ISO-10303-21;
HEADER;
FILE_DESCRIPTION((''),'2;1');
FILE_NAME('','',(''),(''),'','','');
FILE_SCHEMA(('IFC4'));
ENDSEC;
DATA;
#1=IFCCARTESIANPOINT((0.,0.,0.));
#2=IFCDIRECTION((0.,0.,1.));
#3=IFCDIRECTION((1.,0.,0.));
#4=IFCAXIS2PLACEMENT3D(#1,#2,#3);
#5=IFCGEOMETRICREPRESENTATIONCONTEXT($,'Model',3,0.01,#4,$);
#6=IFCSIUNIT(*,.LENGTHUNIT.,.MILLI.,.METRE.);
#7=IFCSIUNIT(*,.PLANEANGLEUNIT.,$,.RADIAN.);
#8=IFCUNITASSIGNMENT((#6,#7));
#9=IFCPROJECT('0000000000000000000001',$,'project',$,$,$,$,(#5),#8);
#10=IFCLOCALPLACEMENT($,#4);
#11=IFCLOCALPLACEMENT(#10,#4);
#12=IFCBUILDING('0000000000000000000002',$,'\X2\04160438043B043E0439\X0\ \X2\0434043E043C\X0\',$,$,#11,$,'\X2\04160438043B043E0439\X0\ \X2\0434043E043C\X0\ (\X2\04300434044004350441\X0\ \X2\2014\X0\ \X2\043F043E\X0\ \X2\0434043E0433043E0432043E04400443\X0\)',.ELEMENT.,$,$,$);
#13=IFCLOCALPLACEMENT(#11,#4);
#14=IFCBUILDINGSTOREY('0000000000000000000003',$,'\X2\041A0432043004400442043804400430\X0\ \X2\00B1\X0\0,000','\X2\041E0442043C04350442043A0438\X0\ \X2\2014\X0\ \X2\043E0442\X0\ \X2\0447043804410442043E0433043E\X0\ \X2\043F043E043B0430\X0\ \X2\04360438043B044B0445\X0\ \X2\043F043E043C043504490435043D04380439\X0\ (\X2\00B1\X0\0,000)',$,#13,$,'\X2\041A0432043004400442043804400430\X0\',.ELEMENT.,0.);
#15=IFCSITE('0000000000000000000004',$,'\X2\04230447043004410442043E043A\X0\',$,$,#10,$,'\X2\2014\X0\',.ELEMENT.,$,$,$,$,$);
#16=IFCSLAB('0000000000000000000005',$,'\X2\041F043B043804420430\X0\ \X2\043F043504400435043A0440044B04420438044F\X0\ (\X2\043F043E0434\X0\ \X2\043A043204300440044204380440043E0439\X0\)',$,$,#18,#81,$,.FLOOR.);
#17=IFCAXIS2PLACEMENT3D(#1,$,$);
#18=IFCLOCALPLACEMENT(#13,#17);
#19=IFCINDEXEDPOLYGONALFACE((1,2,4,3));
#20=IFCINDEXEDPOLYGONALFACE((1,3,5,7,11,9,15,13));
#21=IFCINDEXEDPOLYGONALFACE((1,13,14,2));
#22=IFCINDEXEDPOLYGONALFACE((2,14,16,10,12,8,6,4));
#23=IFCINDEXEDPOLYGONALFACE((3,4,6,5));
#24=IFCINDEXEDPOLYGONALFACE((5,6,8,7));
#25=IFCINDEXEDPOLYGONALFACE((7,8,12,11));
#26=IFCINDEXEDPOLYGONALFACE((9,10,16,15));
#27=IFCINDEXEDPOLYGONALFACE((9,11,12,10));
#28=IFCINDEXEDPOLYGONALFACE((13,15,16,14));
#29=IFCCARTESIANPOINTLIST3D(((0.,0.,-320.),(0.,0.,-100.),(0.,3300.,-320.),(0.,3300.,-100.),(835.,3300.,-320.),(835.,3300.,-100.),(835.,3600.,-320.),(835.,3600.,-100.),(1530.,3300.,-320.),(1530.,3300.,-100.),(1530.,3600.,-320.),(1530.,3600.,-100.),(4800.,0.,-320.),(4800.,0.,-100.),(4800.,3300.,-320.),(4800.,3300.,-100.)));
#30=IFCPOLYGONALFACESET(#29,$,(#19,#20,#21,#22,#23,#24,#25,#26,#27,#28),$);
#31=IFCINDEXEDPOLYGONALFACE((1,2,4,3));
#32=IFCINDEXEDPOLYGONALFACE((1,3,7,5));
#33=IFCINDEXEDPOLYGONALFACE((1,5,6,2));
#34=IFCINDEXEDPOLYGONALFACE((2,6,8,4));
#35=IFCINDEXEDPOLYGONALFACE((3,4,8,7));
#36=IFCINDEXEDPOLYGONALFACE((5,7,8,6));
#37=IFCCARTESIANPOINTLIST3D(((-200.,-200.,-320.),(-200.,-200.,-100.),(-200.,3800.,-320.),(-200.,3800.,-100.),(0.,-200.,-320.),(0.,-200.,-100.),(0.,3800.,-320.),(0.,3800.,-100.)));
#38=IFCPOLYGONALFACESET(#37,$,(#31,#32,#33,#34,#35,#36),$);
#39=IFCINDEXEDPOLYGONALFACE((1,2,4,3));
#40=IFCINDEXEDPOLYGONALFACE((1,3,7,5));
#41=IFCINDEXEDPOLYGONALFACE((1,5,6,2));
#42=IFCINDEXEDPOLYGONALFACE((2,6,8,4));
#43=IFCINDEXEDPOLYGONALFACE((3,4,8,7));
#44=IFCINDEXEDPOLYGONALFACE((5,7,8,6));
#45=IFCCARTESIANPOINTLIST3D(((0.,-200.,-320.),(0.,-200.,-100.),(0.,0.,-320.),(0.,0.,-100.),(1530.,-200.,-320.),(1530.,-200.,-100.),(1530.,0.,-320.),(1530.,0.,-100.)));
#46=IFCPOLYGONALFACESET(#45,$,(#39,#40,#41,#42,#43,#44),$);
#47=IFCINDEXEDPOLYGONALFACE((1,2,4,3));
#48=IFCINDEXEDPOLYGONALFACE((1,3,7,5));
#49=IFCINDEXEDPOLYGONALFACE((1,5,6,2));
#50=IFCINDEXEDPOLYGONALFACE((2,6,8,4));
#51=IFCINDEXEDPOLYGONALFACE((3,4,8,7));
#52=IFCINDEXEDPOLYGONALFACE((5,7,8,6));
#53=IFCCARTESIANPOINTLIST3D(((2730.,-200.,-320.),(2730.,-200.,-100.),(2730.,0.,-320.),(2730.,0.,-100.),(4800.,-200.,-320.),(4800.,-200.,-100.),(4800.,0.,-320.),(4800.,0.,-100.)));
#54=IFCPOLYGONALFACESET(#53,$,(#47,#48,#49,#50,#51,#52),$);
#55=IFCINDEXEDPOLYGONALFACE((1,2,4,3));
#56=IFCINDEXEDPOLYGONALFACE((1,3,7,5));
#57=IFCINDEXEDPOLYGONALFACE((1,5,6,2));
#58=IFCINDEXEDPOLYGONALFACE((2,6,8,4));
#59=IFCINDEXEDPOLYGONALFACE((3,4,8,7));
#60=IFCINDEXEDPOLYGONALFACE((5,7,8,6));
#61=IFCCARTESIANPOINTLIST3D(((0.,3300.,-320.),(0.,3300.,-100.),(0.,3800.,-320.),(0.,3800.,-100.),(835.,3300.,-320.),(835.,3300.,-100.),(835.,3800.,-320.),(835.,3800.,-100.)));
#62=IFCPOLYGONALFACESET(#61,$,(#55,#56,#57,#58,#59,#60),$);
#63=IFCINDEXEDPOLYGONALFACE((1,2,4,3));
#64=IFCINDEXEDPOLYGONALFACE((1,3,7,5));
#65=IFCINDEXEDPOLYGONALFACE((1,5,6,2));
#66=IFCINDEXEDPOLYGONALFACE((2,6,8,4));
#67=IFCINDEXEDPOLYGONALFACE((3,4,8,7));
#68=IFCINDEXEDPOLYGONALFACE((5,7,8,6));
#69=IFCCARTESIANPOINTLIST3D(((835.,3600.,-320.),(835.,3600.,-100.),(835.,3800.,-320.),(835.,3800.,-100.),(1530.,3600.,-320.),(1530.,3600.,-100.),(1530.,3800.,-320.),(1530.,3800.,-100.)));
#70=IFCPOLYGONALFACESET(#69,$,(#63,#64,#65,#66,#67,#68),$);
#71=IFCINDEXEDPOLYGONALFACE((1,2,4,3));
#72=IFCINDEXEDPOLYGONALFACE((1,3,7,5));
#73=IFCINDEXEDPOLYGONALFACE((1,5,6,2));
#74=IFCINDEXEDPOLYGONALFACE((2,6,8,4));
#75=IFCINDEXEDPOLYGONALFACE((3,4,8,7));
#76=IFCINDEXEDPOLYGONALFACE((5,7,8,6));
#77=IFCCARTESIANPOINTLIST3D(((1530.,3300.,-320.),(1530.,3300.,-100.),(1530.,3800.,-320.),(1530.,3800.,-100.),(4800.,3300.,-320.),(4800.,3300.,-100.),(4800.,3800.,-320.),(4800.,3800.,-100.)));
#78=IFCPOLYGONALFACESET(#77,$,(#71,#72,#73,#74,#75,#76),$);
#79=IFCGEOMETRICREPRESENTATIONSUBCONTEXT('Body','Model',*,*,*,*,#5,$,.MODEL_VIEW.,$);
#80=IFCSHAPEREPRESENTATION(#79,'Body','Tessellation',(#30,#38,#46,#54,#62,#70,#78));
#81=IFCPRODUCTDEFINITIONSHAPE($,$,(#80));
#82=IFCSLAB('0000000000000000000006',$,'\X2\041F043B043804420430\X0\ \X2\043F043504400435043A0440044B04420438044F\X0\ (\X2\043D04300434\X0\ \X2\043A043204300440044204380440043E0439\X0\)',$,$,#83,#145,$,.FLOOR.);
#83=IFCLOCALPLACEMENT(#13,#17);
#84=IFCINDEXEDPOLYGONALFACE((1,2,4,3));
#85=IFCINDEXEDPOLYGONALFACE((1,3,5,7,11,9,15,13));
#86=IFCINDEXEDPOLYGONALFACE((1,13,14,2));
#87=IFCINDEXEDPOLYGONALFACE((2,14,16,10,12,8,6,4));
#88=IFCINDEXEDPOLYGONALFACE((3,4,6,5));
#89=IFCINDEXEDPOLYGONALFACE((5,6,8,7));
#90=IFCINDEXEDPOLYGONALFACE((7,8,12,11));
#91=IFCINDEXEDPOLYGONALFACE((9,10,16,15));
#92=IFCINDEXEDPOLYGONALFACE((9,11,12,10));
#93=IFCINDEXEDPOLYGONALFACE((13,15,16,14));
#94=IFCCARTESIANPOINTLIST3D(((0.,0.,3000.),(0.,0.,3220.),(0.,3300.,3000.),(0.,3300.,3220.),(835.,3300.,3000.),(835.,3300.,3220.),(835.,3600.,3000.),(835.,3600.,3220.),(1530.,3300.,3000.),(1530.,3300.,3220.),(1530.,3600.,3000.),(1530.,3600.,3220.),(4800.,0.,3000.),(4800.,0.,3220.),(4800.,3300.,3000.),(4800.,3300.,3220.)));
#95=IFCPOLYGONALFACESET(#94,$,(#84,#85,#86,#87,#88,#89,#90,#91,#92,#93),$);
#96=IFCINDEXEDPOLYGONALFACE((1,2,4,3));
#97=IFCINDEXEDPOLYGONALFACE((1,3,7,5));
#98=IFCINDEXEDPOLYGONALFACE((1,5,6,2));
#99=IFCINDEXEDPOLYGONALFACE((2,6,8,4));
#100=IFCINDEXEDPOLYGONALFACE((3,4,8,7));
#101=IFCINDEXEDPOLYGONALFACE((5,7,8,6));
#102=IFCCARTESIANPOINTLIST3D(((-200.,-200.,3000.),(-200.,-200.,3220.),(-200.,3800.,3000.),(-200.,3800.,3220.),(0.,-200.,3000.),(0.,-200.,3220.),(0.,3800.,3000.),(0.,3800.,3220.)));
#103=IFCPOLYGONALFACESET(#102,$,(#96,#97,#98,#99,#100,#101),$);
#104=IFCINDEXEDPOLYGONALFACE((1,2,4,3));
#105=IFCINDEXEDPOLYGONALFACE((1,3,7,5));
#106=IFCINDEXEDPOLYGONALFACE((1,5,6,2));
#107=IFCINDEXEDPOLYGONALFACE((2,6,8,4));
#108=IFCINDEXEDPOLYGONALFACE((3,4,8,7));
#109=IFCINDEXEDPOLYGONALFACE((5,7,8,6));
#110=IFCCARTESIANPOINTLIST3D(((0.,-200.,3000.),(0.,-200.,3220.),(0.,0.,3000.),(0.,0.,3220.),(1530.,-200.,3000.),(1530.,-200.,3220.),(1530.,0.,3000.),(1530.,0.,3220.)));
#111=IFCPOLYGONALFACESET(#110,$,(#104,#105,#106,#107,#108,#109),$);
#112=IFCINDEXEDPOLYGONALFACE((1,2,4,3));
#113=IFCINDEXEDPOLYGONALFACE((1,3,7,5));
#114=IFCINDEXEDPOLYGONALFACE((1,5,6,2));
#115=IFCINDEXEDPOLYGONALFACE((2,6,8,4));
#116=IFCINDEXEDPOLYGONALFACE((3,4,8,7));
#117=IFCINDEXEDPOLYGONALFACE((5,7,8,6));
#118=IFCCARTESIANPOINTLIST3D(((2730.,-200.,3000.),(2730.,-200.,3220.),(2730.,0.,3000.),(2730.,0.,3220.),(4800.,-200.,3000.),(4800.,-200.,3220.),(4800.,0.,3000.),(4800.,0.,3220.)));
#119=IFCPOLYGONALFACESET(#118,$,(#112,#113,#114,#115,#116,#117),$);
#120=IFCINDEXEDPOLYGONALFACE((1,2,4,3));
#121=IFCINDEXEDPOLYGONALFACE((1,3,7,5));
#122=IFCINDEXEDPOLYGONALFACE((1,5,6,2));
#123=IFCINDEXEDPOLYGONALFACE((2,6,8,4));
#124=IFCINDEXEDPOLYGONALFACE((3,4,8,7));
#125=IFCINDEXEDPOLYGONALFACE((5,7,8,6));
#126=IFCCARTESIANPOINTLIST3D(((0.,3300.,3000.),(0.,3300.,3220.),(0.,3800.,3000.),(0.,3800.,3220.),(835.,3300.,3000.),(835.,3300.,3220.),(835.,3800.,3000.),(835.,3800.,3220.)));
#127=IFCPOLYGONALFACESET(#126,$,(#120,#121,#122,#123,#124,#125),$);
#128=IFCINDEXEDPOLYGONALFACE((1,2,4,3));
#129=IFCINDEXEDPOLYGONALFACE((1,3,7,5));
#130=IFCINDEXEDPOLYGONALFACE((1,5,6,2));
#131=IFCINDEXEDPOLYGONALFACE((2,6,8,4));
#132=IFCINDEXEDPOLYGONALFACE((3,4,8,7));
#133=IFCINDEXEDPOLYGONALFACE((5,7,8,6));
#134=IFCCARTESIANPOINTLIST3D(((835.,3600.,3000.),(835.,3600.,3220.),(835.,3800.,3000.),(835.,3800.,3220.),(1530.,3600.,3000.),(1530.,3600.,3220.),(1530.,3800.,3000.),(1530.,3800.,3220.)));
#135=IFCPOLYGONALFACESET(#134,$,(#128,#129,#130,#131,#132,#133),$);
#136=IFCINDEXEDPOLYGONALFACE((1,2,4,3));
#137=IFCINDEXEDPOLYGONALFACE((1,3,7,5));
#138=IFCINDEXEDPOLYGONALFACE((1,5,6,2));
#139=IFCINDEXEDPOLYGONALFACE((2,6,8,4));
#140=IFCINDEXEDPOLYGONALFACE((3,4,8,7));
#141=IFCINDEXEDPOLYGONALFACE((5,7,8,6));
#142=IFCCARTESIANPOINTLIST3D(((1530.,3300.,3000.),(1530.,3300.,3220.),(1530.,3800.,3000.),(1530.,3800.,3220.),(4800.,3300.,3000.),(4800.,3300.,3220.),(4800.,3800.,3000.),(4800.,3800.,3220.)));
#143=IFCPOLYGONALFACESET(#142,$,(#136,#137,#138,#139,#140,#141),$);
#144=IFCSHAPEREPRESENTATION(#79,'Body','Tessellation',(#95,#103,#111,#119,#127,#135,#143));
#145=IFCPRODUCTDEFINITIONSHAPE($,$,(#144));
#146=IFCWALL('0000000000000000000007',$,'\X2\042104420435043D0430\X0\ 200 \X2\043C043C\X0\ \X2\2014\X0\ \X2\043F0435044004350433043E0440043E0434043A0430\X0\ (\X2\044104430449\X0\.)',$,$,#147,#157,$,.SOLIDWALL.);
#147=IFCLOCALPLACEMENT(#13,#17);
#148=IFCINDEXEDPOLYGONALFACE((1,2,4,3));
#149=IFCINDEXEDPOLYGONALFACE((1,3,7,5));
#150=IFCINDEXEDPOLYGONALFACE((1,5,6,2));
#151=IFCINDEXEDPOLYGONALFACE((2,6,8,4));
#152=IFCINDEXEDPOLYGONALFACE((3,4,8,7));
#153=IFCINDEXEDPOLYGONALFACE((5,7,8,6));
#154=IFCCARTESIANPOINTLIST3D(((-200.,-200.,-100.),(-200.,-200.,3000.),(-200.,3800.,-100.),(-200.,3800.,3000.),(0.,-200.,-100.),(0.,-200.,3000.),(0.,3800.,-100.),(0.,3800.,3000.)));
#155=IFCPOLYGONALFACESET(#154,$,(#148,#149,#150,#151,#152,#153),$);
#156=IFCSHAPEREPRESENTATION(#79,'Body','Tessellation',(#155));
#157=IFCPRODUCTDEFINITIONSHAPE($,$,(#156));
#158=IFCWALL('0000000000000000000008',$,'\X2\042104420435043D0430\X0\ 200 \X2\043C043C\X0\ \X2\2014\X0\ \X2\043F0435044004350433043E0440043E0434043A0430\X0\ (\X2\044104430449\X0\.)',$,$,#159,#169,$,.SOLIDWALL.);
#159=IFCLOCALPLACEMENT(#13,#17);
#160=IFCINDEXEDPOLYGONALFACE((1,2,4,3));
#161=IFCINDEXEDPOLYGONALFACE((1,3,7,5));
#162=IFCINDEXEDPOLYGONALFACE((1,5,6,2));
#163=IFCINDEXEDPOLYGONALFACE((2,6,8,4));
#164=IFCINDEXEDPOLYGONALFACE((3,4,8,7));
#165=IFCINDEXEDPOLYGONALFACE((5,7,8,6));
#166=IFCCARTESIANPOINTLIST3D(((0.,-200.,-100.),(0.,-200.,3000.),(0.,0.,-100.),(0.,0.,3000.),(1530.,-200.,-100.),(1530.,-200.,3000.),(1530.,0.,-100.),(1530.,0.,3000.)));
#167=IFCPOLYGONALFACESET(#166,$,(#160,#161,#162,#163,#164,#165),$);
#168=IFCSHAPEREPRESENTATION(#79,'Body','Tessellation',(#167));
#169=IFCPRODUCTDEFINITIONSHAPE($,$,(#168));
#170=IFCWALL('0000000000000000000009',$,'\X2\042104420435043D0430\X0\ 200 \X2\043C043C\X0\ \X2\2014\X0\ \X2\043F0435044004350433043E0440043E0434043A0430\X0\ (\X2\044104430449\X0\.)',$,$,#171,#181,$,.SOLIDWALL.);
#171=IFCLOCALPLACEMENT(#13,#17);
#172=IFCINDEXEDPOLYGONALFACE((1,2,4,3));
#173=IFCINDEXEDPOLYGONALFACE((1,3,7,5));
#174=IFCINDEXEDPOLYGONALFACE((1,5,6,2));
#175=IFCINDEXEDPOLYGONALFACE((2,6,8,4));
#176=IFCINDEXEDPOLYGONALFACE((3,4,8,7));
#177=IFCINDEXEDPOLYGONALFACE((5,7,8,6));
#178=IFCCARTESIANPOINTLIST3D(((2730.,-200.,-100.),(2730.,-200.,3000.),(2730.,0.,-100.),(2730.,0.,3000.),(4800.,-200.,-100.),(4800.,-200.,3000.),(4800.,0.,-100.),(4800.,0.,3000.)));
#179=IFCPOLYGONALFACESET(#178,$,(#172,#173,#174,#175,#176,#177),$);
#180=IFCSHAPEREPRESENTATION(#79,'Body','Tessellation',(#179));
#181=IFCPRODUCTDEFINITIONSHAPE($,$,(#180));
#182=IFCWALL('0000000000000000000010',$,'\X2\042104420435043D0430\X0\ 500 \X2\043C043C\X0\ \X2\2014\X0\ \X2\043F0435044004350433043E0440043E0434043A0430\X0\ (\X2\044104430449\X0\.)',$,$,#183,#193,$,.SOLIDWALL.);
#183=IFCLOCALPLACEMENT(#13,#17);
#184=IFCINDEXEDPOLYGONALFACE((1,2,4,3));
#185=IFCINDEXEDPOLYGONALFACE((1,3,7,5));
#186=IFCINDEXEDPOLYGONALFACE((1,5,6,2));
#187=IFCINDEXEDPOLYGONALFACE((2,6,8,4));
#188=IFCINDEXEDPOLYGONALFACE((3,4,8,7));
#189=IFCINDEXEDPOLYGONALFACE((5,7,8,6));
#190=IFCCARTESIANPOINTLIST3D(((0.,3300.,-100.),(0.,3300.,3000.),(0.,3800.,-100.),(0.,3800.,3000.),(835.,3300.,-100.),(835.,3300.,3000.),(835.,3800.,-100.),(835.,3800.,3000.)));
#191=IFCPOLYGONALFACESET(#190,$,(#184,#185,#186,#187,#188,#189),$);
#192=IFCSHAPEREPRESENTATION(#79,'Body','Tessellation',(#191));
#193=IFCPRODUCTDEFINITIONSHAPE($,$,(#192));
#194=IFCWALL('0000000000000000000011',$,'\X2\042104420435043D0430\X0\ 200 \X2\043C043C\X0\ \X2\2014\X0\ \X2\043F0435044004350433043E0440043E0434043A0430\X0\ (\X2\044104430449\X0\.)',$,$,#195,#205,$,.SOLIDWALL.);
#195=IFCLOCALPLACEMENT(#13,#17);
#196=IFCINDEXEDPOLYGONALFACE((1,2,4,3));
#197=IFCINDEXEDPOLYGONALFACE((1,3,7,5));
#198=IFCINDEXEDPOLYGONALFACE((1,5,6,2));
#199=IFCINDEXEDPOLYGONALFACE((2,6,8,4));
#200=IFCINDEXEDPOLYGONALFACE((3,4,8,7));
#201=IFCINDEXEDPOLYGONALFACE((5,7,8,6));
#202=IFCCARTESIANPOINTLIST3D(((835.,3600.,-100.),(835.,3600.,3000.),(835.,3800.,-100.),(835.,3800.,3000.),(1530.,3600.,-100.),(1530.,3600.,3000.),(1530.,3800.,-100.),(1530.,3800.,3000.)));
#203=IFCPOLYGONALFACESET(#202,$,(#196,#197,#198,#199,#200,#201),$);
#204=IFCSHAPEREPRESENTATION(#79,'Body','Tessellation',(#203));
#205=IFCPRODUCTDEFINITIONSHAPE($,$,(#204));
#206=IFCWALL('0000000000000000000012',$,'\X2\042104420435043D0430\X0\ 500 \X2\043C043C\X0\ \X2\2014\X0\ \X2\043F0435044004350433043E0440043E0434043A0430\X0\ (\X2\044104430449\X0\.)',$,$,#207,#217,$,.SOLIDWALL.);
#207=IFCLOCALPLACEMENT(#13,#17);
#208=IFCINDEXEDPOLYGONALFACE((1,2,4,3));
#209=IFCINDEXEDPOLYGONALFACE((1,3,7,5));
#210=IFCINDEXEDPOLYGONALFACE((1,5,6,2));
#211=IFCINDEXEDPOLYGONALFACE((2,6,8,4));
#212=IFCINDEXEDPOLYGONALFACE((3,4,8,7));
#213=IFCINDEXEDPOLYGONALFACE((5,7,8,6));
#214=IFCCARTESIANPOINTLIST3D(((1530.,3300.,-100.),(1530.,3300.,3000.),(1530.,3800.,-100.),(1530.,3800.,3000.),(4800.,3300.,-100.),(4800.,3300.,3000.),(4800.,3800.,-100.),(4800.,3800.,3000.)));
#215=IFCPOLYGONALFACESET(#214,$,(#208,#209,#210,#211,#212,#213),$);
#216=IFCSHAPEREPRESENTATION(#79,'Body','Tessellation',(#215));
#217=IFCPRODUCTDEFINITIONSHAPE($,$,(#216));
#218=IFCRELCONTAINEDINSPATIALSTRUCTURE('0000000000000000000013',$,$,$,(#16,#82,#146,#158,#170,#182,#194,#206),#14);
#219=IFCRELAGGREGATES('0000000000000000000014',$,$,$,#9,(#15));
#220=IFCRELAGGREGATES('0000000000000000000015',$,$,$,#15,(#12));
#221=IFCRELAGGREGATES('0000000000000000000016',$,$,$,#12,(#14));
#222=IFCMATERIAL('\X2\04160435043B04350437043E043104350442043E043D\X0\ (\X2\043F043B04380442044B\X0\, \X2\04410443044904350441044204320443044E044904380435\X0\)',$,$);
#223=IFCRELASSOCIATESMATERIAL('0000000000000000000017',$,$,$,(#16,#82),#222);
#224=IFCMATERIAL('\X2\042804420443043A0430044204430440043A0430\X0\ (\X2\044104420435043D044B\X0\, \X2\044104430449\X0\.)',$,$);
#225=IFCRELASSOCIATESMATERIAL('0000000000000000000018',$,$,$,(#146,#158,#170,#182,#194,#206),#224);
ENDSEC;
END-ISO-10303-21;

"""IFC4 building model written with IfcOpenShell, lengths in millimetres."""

from ifc_helpers import new_model, si_unit, frame, origin, origin_with_axes, place, context, subcontext, project, spatial, polyline, outline, extrude, material, element, save


model = new_model("IFC4")

# Units and contexts
model_context = context("Model", 3, precision=0.01, world=origin_with_axes())
body_context = subcontext(model_context, "Body", "Model", "MODEL_VIEW")
ifc_project = project(units=[si_unit("LENGTHUNIT", "METRE", prefix="MILLI"), si_unit("PLANEANGLEUNIT", "RADIAN")], contexts=[model_context])

# Site, building, storey
site_placement = place(None, origin_with_axes())
site = spatial("IfcSite", under=ifc_project, at=site_placement, Name="Участок", LongName="—", CompositionType="ELEMENT")
building_placement = place(site_placement, origin_with_axes())
building = spatial("IfcBuilding", under=site, at=building_placement, Name="Жилой дом", LongName="Жилой дом (адрес — по договору)", CompositionType="ELEMENT")
storey_placement = place(building_placement, origin_with_axes())
storey = spatial("IfcBuildingStorey", under=building, at=storey_placement, Name="Квартира ±0,000", Description="Отметки — от чистого пола жилых помещений (±0,000)", LongName="Квартира", CompositionType="ELEMENT", Elevation=0.0)

# Slabs
ifc_material_1 = material(Name="Железобетон (плиты, существующие)")
for number, where, name in (
    (1, (-200.0, -200.0, -320.0), "Плита перекрытия (под квартирой)"),
    (2, (-200.0, -200.0, 3000.0), "Плита перекрытия (над квартирой)"),
):
    element("IfcSlab", number, at=place(storey_placement, frame(where)), inside=storey, material=ifc_material_1, Name=name, PredefinedType="FLOOR", context=body_context, shape_type="SweptSolid", body=[
        extrude(outline(polyline([(200.0, 200.0), (200.0, 3500.0), (1035.0, 3500.0), (1035.0, 3800.0), (1730.0, 3800.0), (1730.0, 3500.0), (5000.0, 3500.0), (5000.0, 200.0), (200.0, 200.0)])), origin(), (0.0, 0.0, 1.0), 220.0),
        extrude(outline(polyline([(0.0, 0.0), (200.0, 0.0), (200.0, 4000.0), (0.0, 4000.0), (0.0, 0.0)])), origin(), (0.0, 0.0, 1.0), 220.0),
        extrude(outline(polyline([(200.0, 0.0), (1730.0, 0.0), (1730.0, 200.0), (200.0, 200.0), (200.0, 0.0)])), origin(), (0.0, 0.0, 1.0), 220.0),
        extrude(outline(polyline([(2930.0, 0.0), (5000.0, 0.0), (5000.0, 200.0), (2930.0, 200.0), (2930.0, 0.0)])), origin(), (0.0, 0.0, 1.0), 220.0),
        extrude(outline(polyline([(200.0, 3500.0), (1035.0, 3500.0), (1035.0, 4000.0), (200.0, 4000.0), (200.0, 3500.0)])), origin(), (0.0, 0.0, 1.0), 220.0),
        extrude(outline(polyline([(1035.0, 3800.0), (1730.0, 3800.0), (1730.0, 4000.0), (1035.0, 4000.0), (1035.0, 3800.0)])), origin(), (0.0, 0.0, 1.0), 220.0),
        extrude(outline(polyline([(1730.0, 3500.0), (5000.0, 3500.0), (5000.0, 4000.0), (1730.0, 4000.0), (1730.0, 3500.0)])), origin(), (0.0, 0.0, 1.0), 220.0),
    ])

# Walls
ifc_material_2 = material(Name="Штукатурка (стены, сущ.)")
wall_1_placement = place(storey_placement, frame((-200.0, -200.0, -100.0)))
element("IfcWall", 3, at=wall_1_placement, inside=storey, material=ifc_material_2, Name="Стена 200 мм — перегородка (сущ.)", PredefinedType="SOLIDWALL", context=body_context, shape_type="SweptSolid", body=[
    extrude(outline(polyline([(0.0, 0.0), (200.0, 0.0), (200.0, 4000.0), (0.0, 4000.0), (0.0, 0.0)])), origin(), (0.0, 0.0, 1.0), 3100.0),
])
wall_2_placement = place(storey_placement, frame((0.0, -200.0, -100.0)))
element("IfcWall", 4, at=wall_2_placement, inside=storey, material=ifc_material_2, Name="Стена 200 мм — перегородка (сущ.)", PredefinedType="SOLIDWALL", context=body_context, shape_type="SweptSolid", body=[
    extrude(outline(polyline([(0.0, 0.0), (1530.0, 0.0), (1530.0, 200.0), (0.0, 200.0), (0.0, 0.0)])), origin(), (0.0, 0.0, 1.0), 3100.0),
])
wall_3_placement = place(storey_placement, frame((2730.0, -200.0, -100.0)))
element("IfcWall", 5, at=wall_3_placement, inside=storey, material=ifc_material_2, Name="Стена 200 мм — перегородка (сущ.)", PredefinedType="SOLIDWALL", context=body_context, shape_type="SweptSolid", body=[
    extrude(outline(polyline([(0.0, 0.0), (2070.0, 0.0), (2070.0, 200.0), (0.0, 200.0), (0.0, 0.0)])), origin(), (0.0, 0.0, 1.0), 3100.0),
])
wall_4_placement = place(storey_placement, frame((0.0, 3300.0, -100.0)))
element("IfcWall", 6, at=wall_4_placement, inside=storey, material=ifc_material_2, Name="Стена 500 мм — перегородка (сущ.)", PredefinedType="SOLIDWALL", context=body_context, shape_type="SweptSolid", body=[
    extrude(outline(polyline([(0.0, 0.0), (835.0, 0.0), (835.0, 500.0), (0.0, 500.0), (0.0, 0.0)])), origin(), (0.0, 0.0, 1.0), 3100.0),
])
wall_5_placement = place(storey_placement, frame((835.0, 3600.0, -100.0)))
element("IfcWall", 7, at=wall_5_placement, inside=storey, material=ifc_material_2, Name="Стена 200 мм — перегородка (сущ.)", PredefinedType="SOLIDWALL", context=body_context, shape_type="SweptSolid", body=[
    extrude(outline(polyline([(0.0, 0.0), (695.0, 0.0), (695.0, 200.0), (0.0, 200.0), (0.0, 0.0)])), origin(), (0.0, 0.0, 1.0), 3100.0),
])
wall_6_placement = place(storey_placement, frame((1530.0, 3300.0, -100.0)))
element("IfcWall", 8, at=wall_6_placement, inside=storey, material=ifc_material_2, Name="Стена 500 мм — перегородка (сущ.)", PredefinedType="SOLIDWALL", context=body_context, shape_type="SweptSolid", body=[
    extrude(outline(polyline([(0.0, 0.0), (3270.0, 0.0), (3270.0, 500.0), (0.0, 500.0), (0.0, 0.0)])), origin(), (0.0, 0.0, 1.0), 3100.0),
])

save(model, "model.ifc")
